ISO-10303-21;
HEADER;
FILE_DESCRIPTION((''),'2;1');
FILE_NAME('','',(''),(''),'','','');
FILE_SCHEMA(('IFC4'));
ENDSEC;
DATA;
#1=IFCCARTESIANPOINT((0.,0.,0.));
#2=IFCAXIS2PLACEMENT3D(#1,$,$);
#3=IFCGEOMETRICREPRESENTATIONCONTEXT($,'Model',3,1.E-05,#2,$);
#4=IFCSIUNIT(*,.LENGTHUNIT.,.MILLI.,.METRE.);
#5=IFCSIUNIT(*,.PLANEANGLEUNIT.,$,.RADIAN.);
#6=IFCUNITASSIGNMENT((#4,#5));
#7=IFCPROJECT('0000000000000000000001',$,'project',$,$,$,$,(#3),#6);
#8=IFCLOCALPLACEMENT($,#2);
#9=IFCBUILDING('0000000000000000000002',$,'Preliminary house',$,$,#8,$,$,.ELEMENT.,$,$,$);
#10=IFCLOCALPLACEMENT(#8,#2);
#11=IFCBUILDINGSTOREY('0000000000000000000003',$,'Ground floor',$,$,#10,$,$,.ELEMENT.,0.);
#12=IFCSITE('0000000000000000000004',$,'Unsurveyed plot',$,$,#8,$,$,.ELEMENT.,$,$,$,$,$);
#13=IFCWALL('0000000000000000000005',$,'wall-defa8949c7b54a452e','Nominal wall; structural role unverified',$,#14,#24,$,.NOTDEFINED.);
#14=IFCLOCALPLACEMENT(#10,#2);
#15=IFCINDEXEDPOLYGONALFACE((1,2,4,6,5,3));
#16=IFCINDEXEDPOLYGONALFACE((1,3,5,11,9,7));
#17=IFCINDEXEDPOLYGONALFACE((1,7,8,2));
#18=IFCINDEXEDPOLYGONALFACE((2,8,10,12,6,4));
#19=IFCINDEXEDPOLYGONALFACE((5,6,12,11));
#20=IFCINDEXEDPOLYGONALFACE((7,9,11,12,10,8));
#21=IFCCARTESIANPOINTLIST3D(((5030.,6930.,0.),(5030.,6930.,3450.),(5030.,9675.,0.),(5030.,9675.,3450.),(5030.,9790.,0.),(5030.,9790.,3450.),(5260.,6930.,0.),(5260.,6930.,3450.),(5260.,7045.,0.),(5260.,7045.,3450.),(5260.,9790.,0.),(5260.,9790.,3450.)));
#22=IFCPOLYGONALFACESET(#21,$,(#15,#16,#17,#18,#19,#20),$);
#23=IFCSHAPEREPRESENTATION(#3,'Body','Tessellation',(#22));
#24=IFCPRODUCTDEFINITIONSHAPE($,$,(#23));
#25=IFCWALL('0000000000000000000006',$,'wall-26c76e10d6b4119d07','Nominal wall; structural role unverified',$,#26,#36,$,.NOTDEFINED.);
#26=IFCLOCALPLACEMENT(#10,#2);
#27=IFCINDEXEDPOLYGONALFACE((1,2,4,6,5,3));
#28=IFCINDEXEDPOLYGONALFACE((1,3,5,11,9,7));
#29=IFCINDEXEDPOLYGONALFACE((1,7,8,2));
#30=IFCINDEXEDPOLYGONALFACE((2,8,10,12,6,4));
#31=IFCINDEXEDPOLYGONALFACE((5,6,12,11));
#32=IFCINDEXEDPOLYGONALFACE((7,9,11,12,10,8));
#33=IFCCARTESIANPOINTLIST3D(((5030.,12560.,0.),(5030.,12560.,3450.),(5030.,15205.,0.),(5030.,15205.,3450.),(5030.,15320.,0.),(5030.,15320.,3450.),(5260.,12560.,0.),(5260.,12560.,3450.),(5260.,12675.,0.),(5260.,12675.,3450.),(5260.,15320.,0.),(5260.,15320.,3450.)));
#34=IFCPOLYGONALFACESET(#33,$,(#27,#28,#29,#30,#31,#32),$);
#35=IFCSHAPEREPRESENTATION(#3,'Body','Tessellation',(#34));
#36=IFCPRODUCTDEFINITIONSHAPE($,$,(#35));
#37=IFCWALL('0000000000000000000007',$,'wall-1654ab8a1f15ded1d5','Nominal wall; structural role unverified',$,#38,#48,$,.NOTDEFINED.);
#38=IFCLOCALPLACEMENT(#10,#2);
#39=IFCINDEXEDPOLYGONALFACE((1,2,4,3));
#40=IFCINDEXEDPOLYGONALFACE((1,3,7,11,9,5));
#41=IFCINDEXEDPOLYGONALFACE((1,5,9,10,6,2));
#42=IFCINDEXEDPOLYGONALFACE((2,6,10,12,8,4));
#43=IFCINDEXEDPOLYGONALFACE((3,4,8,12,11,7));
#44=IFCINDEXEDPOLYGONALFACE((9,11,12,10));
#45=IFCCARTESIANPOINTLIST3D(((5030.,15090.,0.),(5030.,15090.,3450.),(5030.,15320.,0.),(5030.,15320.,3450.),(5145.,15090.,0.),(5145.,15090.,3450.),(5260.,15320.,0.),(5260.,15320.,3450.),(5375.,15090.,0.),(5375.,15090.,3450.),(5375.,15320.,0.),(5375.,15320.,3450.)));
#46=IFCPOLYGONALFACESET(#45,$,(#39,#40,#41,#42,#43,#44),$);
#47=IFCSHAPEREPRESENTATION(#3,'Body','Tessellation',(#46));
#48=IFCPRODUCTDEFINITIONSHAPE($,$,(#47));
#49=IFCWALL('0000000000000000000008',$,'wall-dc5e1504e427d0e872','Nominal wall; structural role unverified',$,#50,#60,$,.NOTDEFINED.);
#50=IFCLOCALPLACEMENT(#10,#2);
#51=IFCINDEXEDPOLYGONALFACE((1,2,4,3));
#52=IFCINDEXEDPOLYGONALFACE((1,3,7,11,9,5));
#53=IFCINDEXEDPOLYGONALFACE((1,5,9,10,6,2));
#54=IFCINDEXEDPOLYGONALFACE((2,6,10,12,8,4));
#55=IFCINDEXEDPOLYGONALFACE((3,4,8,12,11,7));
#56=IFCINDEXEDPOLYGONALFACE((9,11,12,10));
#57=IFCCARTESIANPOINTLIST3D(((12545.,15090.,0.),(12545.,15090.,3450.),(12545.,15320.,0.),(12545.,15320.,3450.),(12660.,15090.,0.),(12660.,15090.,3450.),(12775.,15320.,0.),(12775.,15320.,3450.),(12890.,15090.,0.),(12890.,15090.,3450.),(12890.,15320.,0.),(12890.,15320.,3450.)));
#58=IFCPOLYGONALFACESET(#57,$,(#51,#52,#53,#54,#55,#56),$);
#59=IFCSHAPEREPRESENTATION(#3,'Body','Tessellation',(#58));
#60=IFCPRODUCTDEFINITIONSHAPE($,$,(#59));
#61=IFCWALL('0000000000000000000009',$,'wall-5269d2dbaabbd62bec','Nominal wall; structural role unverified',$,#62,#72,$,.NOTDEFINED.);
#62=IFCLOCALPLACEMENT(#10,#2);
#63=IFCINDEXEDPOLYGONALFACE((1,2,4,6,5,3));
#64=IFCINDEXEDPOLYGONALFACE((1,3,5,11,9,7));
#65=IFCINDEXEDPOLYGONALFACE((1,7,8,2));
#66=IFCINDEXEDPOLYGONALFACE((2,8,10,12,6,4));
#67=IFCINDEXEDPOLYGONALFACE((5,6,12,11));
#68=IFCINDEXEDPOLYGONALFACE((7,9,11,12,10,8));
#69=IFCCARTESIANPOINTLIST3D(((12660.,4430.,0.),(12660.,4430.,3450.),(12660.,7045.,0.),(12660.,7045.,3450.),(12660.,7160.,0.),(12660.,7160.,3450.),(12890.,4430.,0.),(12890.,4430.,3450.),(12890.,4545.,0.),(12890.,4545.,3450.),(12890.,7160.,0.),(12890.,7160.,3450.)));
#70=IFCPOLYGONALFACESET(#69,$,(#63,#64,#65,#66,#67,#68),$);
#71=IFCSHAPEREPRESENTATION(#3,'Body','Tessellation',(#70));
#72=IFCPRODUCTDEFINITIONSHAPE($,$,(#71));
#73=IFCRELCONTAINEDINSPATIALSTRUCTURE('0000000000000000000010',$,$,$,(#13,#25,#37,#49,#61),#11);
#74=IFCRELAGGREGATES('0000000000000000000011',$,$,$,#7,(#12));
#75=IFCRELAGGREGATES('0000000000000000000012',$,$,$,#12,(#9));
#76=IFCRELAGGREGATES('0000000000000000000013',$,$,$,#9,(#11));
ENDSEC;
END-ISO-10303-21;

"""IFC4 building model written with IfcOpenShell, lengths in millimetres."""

from ifc_helpers import new_model, si_unit, origin, place, context, project, spatial, polyline, outline, extrude, element, save


model = new_model("IFC4")

# Units and contexts
model_context = context("Model", 3, precision=1e-05, world=origin())
ifc_project = project(units=[si_unit("LENGTHUNIT", "METRE", prefix="MILLI"), si_unit("PLANEANGLEUNIT", "RADIAN")], contexts=[model_context])

# Site, building, storey
placement_1 = place(None, origin())
site = spatial("IfcSite", under=ifc_project, at=placement_1, Name="Unsurveyed plot", CompositionType="ELEMENT")
building = spatial("IfcBuilding", under=site, at=placement_1, Name="Preliminary house", CompositionType="ELEMENT")
placement_2 = place(placement_1, origin())
storey = spatial("IfcBuildingStorey", under=building, at=placement_2, Name="Ground floor", CompositionType="ELEMENT", Elevation=0.0)

# Wall
element("IfcWall", 1, at=placement_2, inside=storey, Name="wall-defa8949c7b54a452e", Description="Nominal wall; structural role unverified", PredefinedType="NOTDEFINED", context=model_context, shape_type="SweptSolid", body=[
    extrude(outline(polyline([(5030.0, 9675.0), (5030.0, 9790.0), (5260.0, 9790.0), (5260.0, 7045.0), (5260.0, 6930.0), (5030.0, 6930.0), (5030.0, 9675.0)])), origin(), (0.0, 0.0, 1.0), 3450.0),
])

# Walls
element("IfcWall", 2, at=placement_2, inside=storey, Name="wall-26c76e10d6b4119d07", Description="Nominal wall; structural role unverified", PredefinedType="NOTDEFINED", context=model_context, shape_type="SweptSolid", body=[
    extrude(outline(polyline([(5030.0, 15205.0), (5030.0, 15320.0), (5260.0, 15320.0), (5260.0, 12675.0), (5260.0, 12560.0), (5030.0, 12560.0), (5030.0, 15205.0)])), origin(), (0.0, 0.0, 1.0), 3450.0),
])
element("IfcWall", 3, at=placement_2, inside=storey, Name="wall-1654ab8a1f15ded1d5", Description="Nominal wall; structural role unverified", PredefinedType="NOTDEFINED", context=model_context, shape_type="SweptSolid", body=[
    extrude(outline(polyline([(5260.0, 15320.0), (5375.0, 15320.0), (5375.0, 15090.0), (5145.0, 15090.0), (5030.0, 15090.0), (5030.0, 15320.0), (5260.0, 15320.0)])), origin(), (0.0, 0.0, 1.0), 3450.0),
])

# Wall
element("IfcWall", 4, at=placement_2, inside=storey, Name="wall-dc5e1504e427d0e872", Description="Nominal wall; structural role unverified", PredefinedType="NOTDEFINED", context=model_context, shape_type="SweptSolid", body=[
    extrude(outline(polyline([(12775.0, 15320.0), (12890.0, 15320.0), (12890.0, 15090.0), (12660.0, 15090.0), (12545.0, 15090.0), (12545.0, 15320.0), (12775.0, 15320.0)])), origin(), (0.0, 0.0, 1.0), 3450.0),
])

# Wall
element("IfcWall", 5, at=placement_2, inside=storey, Name="wall-5269d2dbaabbd62bec", Description="Nominal wall; structural role unverified", PredefinedType="NOTDEFINED", context=model_context, shape_type="SweptSolid", body=[
    extrude(outline(polyline([(12660.0, 7045.0), (12660.0, 7160.0), (12890.0, 7160.0), (12890.0, 4545.0), (12890.0, 4430.0), (12660.0, 4430.0), (12660.0, 7045.0)])), origin(), (0.0, 0.0, 1.0), 3450.0),
])

save(model, "model.ifc")
